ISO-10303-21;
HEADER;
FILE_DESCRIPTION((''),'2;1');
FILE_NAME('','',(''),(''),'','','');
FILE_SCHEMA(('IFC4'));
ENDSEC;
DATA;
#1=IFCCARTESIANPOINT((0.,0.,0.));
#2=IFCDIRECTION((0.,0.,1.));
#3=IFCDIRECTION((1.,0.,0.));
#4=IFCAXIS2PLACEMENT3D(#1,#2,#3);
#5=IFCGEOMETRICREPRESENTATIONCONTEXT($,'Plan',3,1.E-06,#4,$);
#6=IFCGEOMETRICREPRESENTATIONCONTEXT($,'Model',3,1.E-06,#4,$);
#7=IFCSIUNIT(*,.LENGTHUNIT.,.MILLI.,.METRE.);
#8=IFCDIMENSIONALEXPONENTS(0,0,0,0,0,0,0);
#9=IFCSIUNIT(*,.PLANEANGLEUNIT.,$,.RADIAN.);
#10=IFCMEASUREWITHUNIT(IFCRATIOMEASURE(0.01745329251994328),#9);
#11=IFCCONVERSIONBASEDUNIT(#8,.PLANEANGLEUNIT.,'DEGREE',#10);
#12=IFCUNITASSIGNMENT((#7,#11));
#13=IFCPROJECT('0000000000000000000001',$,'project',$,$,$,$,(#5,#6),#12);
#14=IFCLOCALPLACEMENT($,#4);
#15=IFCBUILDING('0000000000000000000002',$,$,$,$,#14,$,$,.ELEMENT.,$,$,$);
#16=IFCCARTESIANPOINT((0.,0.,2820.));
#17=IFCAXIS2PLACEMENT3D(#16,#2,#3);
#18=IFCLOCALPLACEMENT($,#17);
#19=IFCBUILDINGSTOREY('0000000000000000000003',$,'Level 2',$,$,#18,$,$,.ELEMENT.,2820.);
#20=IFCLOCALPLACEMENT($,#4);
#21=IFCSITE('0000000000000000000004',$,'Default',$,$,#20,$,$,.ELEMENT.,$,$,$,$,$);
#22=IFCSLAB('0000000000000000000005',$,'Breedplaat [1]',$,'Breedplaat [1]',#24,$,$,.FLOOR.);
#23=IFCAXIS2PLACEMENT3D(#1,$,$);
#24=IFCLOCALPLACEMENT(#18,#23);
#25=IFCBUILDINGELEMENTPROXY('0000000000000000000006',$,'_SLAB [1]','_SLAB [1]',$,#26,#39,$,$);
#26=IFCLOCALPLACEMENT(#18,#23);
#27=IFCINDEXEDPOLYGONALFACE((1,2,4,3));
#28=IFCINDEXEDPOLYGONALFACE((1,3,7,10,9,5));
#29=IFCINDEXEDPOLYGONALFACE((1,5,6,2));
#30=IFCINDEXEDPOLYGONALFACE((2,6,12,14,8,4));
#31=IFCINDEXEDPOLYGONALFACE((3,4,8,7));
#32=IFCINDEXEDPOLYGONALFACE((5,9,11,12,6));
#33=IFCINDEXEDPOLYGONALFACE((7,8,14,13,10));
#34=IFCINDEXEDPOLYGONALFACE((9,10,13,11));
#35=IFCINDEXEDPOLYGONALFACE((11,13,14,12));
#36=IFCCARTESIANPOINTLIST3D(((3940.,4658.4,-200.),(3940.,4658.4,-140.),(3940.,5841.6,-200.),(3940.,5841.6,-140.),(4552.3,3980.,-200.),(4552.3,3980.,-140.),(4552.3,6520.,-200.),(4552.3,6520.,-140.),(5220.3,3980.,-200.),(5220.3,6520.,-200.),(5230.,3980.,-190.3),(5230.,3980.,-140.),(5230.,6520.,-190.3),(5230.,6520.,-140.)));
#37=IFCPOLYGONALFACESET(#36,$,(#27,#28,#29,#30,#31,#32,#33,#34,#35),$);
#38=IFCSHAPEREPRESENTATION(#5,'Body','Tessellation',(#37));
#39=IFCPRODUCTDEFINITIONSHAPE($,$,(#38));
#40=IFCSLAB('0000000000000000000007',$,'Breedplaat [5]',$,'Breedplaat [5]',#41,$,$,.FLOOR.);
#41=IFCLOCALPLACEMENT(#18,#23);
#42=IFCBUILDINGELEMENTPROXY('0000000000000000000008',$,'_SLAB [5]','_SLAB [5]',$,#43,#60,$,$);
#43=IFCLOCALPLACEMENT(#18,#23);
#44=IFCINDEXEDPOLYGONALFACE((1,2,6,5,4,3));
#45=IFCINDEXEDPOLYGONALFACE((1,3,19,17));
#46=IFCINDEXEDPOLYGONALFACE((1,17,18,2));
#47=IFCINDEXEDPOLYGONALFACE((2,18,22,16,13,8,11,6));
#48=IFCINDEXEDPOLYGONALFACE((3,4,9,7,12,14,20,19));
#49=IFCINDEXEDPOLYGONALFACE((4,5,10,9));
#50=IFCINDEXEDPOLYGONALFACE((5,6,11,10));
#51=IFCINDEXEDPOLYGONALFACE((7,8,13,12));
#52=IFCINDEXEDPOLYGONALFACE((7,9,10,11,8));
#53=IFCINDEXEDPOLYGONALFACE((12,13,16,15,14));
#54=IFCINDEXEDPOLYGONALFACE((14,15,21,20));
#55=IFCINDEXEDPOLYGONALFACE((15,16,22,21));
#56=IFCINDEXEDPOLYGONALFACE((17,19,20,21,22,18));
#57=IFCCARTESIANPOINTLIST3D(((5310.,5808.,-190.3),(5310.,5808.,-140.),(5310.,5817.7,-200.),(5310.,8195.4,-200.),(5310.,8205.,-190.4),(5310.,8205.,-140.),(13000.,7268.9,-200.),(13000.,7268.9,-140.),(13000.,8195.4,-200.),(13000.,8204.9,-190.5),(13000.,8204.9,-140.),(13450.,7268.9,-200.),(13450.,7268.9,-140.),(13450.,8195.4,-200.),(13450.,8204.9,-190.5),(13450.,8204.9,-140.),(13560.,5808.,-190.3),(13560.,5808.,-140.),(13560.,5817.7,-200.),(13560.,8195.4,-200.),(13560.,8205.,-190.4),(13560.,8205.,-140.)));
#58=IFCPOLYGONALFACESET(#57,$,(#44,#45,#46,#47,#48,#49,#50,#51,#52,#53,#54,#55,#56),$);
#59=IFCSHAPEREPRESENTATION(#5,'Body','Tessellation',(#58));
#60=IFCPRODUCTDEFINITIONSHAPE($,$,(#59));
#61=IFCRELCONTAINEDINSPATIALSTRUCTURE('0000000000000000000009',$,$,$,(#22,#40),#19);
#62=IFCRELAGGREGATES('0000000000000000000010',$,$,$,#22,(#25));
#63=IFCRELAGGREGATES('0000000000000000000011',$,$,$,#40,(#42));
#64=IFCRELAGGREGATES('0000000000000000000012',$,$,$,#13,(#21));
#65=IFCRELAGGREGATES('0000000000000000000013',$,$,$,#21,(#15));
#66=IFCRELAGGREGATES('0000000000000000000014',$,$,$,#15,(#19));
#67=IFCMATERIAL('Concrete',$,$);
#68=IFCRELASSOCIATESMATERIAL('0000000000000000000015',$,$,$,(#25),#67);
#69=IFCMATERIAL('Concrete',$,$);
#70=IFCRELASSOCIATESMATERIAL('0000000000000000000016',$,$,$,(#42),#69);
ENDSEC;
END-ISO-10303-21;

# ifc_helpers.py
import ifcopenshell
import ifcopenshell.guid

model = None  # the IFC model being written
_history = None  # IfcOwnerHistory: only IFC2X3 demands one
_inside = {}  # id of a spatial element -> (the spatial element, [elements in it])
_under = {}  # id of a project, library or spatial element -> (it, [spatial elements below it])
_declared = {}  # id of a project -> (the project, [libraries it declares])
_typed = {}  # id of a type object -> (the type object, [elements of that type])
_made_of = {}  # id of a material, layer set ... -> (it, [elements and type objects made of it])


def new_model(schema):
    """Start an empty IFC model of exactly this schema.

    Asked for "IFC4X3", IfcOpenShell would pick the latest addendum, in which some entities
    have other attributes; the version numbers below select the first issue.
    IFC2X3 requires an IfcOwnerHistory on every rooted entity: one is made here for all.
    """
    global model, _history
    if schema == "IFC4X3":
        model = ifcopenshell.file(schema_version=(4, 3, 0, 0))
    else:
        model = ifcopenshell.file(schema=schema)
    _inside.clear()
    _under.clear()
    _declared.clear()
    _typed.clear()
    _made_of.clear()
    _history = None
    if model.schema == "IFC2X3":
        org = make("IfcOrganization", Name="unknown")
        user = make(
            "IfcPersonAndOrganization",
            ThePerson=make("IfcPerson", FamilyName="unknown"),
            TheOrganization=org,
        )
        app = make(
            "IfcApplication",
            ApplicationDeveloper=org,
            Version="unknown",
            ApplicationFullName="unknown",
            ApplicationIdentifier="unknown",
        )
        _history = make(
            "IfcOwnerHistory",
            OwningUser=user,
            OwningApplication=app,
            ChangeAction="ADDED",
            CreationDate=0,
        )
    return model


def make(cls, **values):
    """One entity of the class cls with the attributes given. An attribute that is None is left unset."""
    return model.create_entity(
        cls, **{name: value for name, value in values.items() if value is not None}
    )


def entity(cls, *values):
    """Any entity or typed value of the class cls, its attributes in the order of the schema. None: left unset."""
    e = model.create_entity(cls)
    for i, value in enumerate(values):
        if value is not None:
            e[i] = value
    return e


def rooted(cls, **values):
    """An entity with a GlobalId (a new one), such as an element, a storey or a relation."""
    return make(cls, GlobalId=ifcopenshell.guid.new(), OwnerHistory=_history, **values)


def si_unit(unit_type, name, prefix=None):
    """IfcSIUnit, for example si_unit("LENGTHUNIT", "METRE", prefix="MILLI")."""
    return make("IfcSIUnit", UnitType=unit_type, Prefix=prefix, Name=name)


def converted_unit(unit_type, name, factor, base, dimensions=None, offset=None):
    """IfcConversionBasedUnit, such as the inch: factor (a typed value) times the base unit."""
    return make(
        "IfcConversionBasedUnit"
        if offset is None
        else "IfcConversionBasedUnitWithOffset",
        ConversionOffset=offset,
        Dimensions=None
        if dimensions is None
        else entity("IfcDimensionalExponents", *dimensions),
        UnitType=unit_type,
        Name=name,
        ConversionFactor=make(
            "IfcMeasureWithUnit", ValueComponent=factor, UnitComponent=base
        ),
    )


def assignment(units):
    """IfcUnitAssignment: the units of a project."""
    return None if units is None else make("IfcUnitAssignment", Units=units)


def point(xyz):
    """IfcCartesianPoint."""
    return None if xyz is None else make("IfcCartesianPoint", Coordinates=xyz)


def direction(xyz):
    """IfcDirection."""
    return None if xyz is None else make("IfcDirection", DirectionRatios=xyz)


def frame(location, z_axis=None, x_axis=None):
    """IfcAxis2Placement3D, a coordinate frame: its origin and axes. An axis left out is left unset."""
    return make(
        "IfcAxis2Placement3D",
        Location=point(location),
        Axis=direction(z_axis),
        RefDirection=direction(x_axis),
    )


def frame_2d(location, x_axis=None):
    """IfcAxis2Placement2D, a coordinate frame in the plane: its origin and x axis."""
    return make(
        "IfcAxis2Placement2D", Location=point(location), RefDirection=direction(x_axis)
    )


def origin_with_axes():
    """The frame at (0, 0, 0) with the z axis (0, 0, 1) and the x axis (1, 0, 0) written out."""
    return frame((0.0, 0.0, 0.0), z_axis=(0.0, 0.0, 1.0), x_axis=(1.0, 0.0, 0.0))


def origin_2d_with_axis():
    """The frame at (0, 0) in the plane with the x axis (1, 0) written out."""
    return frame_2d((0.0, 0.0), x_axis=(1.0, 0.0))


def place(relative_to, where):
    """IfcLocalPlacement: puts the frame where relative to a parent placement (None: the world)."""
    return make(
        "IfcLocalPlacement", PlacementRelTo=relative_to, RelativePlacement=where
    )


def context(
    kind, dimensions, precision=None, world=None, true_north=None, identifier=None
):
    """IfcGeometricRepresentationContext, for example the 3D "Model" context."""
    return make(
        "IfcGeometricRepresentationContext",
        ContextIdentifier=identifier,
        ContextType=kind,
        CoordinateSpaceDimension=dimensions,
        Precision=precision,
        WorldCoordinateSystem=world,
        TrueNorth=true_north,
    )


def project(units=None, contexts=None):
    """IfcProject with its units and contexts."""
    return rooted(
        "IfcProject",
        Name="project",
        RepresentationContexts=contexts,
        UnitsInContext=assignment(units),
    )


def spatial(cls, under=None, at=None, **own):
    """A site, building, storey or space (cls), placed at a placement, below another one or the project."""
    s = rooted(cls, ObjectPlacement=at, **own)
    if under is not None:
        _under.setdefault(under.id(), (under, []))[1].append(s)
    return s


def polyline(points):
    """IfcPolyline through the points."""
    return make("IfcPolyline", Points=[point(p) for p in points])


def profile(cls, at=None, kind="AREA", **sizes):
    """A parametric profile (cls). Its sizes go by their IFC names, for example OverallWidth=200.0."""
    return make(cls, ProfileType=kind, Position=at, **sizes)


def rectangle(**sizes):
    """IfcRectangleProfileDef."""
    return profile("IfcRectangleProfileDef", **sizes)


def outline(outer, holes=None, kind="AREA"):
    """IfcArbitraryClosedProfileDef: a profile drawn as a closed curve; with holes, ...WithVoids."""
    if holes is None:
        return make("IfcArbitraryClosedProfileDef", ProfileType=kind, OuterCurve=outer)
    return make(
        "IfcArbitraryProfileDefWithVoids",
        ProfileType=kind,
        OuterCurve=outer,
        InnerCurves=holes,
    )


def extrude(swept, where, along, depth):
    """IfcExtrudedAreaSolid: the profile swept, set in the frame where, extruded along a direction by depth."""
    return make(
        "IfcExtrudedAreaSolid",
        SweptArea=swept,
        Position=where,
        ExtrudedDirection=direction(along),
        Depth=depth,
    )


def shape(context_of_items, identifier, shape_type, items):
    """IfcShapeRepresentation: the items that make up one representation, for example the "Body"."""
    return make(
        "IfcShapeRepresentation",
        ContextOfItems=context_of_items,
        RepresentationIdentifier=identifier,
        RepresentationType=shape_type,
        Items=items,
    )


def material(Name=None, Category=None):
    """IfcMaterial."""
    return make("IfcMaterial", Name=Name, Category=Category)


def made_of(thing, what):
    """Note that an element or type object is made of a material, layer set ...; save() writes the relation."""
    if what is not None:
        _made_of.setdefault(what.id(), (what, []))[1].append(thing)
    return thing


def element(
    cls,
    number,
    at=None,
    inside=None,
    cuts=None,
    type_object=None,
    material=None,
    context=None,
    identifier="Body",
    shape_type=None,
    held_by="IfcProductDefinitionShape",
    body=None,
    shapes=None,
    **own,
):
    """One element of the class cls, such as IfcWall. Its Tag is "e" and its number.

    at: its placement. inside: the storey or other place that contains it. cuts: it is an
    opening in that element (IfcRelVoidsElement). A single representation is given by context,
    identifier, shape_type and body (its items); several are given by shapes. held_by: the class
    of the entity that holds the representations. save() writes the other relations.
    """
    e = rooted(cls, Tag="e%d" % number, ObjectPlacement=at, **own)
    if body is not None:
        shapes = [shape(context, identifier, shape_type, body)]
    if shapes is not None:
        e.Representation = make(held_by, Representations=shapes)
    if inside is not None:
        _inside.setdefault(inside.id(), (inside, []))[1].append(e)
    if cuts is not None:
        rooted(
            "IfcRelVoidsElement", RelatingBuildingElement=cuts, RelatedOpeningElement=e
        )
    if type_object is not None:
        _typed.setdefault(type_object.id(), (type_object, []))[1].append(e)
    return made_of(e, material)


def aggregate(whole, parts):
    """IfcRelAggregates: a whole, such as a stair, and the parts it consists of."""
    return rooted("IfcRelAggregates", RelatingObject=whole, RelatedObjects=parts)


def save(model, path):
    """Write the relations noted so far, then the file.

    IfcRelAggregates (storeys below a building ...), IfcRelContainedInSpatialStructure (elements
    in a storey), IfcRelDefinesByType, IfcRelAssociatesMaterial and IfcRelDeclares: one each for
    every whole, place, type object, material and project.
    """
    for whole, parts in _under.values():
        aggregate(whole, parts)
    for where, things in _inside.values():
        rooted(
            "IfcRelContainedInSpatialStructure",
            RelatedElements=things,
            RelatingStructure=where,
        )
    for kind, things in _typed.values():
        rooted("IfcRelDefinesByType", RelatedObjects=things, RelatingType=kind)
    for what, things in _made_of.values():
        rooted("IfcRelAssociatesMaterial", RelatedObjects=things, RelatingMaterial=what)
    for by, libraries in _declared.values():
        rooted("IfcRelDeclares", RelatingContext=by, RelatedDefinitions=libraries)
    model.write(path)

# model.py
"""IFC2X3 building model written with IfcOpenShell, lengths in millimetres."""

from ifc_helpers import new_model, entity, si_unit, converted_unit, frame, origin_with_axes, origin_2d_with_axis, place, context, project, spatial, polyline, rectangle, outline, extrude, material, element, aggregate, save


model = new_model("IFC2X3")

# Units and contexts
plan_context = context("Plan", 3, precision=1e-06, world=origin_with_axes())
model_context = context("Model", 3, precision=1e-06, world=origin_with_axes())
ifc_project = project(units=[si_unit("LENGTHUNIT", "METRE", prefix="MILLI"), converted_unit("PLANEANGLEUNIT", "DEGREE", entity("IfcRatioMeasure", 0.01745329251994328), si_unit("PLANEANGLEUNIT", "RADIAN"), dimensions=[0, 0, 0, 0, 0, 0, 0])], contexts=[plan_context, model_context])

# Site, building, storey
site_placement = place(None, origin_with_axes())
site = spatial("IfcSite", under=ifc_project, at=site_placement, Name="Default", CompositionType="ELEMENT")
building_placement = place(None, origin_with_axes())
building = spatial("IfcBuilding", under=site, at=building_placement, CompositionType="ELEMENT")
storey_placement = place(None, frame((0.0, 0.0, 2820.0), z_axis=(0.0, 0.0, 1.0), x_axis=(1.0, 0.0, 0.0)))
storey = spatial("IfcBuildingStorey", under=building, at=storey_placement, Name="Level 2", CompositionType="ELEMENT", Elevation=2820.0)

# Slab, building element proxy, opening
slab_1_placement = place(None, frame((5230.0, 3980.0, 2620.0), z_axis=(0.0, 0.0, 1.0), x_axis=(0.0, 1.0, 0.0)))
slab_1 = element("IfcSlab", 1, at=slab_1_placement, inside=storey, Name="Breedplaat [1]", ObjectType="Breedplaat [1]", PredefinedType="FLOOR")
ifc_material_1 = material(Name="Concrete")
proxy_1_placement = place(slab_1_placement, origin_with_axes())
proxy_1 = element("IfcBuildingElementProxy", 2, at=proxy_1_placement, material=ifc_material_1, Name="_SLAB [1]", Description="_SLAB [1]", context=plan_context, shape_type="SweptSolid", body=[
    extrude(outline(polyline([(2540.0, 0.0), (2540.0, 677.8), (1861.6, 1290.0), (678.4, 1290.0), (0.0, 677.8), (0.0, 0.0), (2540.0, 0.0)])), origin_with_axes(), (0.0, 0.0, 1.0), 60.0),
])
opening_1_placement = place(None, frame((5230.0, 3980.0, 2620.0), z_axis=(0.0, 0.0, 1.0), x_axis=(0.0, 1.0, 0.0)))
element("IfcOpeningElement", 3, at=opening_1_placement, cuts=proxy_1, ObjectType="Opening", context=plan_context, shape_type="SweptSolid", body=[
    extrude(outline(polyline([(-0.1, -0.1), (-0.1, 10.0), (10.0, -0.1), (-0.1, -0.1)])), frame((-1.2, -0.1, -0.1), z_axis=(1.0, 0.0, 0.0), x_axis=(0.0, 1.0, 0.0)), (0.0, 0.0, 1.0), 2542.2),
])
aggregate(slab_1, [proxy_1])

# Slab, building element proxy, openings
slab_2_placement = place(None, frame((5310.0, 5808.0, 2620.0), z_axis=(0.0, 0.0, 1.0), x_axis=(1.0, 0.0, 0.0)))
slab_2 = element("IfcSlab", 4, at=slab_2_placement, inside=storey, Name="Breedplaat [5]", ObjectType="Breedplaat [5]", PredefinedType="FLOOR")
ifc_material_2 = material(Name="Concrete")
proxy_2_placement = place(slab_2_placement, origin_with_axes())
proxy_2 = element("IfcBuildingElementProxy", 5, at=proxy_2_placement, material=ifc_material_2, Name="_SLAB [5]", Description="_SLAB [5]", context=plan_context, shape_type="SweptSolid", body=[
    extrude(outline(polyline([(0.0, 0.0), (8250.0, 0.0), (8250.0, 2397.0), (0.0, 2397.0), (0.0, 0.0)])), origin_with_axes(), (0.0, 0.0, 1.0), 60.0),
])
opening_2_placement = place(slab_2_placement, frame((7690.0, 1460.9, 0.0), z_axis=(0.0, 0.0, 1.0), x_axis=(1.0, 0.0, 0.0)))
element("IfcOpeningElement", 6, at=opening_2_placement, cuts=proxy_2, ObjectType="Opening", context=plan_context, shape_type="SolidModel", body=[
    extrude(rectangle(XDim=450.0, YDim=936.0, at=origin_2d_with_axis()), frame((225.0, 468.0, 0.0), z_axis=(0.0, 0.0, 1.0), x_axis=(1.0, 0.0, 0.0)), (0.0, 0.0, 1.0), 60.0),
])
opening_3_placement = place(None, frame((5310.0, 5808.0, 2620.0), z_axis=(0.0, 0.0, 1.0), x_axis=(1.0, 0.0, 0.0)))
element("IfcOpeningElement", 7, at=opening_3_placement, cuts=proxy_2, ObjectType="Opening", context=plan_context, shape_type="SweptSolid", body=[
    extrude(outline(polyline([(-0.1, -0.1), (-0.1, 10.0), (10.0, -0.1), (-0.1, -0.1)])), frame((-1.2, -0.1, -0.1), z_axis=(1.0, 0.0, 0.0), x_axis=(0.0, 1.0, 0.0)), (0.0, 0.0, 1.0), 8252.2),
])
opening_4_placement = place(None, frame((5310.0, 5808.0, 2620.0), z_axis=(0.0, 0.0, 1.0), x_axis=(1.0, 0.0, 0.0)))
element("IfcOpeningElement", 8, at=opening_4_placement, cuts=proxy_2, ObjectType="Opening", context=plan_context, shape_type="SweptSolid", body=[
    extrude(outline(polyline([(-0.1, -0.1), (-0.1, 10.0), (10.0, -0.1), (-0.1, -0.1)])), frame((8251.2, 2397.2, -0.1), z_axis=(-1.0, 0.0, 0.0), x_axis=(0.0, -1.0, 0.0)), (0.0, 0.0, 1.0), 8252.2),
])
aggregate(slab_2, [proxy_2])

save(model, "model.ifc")
